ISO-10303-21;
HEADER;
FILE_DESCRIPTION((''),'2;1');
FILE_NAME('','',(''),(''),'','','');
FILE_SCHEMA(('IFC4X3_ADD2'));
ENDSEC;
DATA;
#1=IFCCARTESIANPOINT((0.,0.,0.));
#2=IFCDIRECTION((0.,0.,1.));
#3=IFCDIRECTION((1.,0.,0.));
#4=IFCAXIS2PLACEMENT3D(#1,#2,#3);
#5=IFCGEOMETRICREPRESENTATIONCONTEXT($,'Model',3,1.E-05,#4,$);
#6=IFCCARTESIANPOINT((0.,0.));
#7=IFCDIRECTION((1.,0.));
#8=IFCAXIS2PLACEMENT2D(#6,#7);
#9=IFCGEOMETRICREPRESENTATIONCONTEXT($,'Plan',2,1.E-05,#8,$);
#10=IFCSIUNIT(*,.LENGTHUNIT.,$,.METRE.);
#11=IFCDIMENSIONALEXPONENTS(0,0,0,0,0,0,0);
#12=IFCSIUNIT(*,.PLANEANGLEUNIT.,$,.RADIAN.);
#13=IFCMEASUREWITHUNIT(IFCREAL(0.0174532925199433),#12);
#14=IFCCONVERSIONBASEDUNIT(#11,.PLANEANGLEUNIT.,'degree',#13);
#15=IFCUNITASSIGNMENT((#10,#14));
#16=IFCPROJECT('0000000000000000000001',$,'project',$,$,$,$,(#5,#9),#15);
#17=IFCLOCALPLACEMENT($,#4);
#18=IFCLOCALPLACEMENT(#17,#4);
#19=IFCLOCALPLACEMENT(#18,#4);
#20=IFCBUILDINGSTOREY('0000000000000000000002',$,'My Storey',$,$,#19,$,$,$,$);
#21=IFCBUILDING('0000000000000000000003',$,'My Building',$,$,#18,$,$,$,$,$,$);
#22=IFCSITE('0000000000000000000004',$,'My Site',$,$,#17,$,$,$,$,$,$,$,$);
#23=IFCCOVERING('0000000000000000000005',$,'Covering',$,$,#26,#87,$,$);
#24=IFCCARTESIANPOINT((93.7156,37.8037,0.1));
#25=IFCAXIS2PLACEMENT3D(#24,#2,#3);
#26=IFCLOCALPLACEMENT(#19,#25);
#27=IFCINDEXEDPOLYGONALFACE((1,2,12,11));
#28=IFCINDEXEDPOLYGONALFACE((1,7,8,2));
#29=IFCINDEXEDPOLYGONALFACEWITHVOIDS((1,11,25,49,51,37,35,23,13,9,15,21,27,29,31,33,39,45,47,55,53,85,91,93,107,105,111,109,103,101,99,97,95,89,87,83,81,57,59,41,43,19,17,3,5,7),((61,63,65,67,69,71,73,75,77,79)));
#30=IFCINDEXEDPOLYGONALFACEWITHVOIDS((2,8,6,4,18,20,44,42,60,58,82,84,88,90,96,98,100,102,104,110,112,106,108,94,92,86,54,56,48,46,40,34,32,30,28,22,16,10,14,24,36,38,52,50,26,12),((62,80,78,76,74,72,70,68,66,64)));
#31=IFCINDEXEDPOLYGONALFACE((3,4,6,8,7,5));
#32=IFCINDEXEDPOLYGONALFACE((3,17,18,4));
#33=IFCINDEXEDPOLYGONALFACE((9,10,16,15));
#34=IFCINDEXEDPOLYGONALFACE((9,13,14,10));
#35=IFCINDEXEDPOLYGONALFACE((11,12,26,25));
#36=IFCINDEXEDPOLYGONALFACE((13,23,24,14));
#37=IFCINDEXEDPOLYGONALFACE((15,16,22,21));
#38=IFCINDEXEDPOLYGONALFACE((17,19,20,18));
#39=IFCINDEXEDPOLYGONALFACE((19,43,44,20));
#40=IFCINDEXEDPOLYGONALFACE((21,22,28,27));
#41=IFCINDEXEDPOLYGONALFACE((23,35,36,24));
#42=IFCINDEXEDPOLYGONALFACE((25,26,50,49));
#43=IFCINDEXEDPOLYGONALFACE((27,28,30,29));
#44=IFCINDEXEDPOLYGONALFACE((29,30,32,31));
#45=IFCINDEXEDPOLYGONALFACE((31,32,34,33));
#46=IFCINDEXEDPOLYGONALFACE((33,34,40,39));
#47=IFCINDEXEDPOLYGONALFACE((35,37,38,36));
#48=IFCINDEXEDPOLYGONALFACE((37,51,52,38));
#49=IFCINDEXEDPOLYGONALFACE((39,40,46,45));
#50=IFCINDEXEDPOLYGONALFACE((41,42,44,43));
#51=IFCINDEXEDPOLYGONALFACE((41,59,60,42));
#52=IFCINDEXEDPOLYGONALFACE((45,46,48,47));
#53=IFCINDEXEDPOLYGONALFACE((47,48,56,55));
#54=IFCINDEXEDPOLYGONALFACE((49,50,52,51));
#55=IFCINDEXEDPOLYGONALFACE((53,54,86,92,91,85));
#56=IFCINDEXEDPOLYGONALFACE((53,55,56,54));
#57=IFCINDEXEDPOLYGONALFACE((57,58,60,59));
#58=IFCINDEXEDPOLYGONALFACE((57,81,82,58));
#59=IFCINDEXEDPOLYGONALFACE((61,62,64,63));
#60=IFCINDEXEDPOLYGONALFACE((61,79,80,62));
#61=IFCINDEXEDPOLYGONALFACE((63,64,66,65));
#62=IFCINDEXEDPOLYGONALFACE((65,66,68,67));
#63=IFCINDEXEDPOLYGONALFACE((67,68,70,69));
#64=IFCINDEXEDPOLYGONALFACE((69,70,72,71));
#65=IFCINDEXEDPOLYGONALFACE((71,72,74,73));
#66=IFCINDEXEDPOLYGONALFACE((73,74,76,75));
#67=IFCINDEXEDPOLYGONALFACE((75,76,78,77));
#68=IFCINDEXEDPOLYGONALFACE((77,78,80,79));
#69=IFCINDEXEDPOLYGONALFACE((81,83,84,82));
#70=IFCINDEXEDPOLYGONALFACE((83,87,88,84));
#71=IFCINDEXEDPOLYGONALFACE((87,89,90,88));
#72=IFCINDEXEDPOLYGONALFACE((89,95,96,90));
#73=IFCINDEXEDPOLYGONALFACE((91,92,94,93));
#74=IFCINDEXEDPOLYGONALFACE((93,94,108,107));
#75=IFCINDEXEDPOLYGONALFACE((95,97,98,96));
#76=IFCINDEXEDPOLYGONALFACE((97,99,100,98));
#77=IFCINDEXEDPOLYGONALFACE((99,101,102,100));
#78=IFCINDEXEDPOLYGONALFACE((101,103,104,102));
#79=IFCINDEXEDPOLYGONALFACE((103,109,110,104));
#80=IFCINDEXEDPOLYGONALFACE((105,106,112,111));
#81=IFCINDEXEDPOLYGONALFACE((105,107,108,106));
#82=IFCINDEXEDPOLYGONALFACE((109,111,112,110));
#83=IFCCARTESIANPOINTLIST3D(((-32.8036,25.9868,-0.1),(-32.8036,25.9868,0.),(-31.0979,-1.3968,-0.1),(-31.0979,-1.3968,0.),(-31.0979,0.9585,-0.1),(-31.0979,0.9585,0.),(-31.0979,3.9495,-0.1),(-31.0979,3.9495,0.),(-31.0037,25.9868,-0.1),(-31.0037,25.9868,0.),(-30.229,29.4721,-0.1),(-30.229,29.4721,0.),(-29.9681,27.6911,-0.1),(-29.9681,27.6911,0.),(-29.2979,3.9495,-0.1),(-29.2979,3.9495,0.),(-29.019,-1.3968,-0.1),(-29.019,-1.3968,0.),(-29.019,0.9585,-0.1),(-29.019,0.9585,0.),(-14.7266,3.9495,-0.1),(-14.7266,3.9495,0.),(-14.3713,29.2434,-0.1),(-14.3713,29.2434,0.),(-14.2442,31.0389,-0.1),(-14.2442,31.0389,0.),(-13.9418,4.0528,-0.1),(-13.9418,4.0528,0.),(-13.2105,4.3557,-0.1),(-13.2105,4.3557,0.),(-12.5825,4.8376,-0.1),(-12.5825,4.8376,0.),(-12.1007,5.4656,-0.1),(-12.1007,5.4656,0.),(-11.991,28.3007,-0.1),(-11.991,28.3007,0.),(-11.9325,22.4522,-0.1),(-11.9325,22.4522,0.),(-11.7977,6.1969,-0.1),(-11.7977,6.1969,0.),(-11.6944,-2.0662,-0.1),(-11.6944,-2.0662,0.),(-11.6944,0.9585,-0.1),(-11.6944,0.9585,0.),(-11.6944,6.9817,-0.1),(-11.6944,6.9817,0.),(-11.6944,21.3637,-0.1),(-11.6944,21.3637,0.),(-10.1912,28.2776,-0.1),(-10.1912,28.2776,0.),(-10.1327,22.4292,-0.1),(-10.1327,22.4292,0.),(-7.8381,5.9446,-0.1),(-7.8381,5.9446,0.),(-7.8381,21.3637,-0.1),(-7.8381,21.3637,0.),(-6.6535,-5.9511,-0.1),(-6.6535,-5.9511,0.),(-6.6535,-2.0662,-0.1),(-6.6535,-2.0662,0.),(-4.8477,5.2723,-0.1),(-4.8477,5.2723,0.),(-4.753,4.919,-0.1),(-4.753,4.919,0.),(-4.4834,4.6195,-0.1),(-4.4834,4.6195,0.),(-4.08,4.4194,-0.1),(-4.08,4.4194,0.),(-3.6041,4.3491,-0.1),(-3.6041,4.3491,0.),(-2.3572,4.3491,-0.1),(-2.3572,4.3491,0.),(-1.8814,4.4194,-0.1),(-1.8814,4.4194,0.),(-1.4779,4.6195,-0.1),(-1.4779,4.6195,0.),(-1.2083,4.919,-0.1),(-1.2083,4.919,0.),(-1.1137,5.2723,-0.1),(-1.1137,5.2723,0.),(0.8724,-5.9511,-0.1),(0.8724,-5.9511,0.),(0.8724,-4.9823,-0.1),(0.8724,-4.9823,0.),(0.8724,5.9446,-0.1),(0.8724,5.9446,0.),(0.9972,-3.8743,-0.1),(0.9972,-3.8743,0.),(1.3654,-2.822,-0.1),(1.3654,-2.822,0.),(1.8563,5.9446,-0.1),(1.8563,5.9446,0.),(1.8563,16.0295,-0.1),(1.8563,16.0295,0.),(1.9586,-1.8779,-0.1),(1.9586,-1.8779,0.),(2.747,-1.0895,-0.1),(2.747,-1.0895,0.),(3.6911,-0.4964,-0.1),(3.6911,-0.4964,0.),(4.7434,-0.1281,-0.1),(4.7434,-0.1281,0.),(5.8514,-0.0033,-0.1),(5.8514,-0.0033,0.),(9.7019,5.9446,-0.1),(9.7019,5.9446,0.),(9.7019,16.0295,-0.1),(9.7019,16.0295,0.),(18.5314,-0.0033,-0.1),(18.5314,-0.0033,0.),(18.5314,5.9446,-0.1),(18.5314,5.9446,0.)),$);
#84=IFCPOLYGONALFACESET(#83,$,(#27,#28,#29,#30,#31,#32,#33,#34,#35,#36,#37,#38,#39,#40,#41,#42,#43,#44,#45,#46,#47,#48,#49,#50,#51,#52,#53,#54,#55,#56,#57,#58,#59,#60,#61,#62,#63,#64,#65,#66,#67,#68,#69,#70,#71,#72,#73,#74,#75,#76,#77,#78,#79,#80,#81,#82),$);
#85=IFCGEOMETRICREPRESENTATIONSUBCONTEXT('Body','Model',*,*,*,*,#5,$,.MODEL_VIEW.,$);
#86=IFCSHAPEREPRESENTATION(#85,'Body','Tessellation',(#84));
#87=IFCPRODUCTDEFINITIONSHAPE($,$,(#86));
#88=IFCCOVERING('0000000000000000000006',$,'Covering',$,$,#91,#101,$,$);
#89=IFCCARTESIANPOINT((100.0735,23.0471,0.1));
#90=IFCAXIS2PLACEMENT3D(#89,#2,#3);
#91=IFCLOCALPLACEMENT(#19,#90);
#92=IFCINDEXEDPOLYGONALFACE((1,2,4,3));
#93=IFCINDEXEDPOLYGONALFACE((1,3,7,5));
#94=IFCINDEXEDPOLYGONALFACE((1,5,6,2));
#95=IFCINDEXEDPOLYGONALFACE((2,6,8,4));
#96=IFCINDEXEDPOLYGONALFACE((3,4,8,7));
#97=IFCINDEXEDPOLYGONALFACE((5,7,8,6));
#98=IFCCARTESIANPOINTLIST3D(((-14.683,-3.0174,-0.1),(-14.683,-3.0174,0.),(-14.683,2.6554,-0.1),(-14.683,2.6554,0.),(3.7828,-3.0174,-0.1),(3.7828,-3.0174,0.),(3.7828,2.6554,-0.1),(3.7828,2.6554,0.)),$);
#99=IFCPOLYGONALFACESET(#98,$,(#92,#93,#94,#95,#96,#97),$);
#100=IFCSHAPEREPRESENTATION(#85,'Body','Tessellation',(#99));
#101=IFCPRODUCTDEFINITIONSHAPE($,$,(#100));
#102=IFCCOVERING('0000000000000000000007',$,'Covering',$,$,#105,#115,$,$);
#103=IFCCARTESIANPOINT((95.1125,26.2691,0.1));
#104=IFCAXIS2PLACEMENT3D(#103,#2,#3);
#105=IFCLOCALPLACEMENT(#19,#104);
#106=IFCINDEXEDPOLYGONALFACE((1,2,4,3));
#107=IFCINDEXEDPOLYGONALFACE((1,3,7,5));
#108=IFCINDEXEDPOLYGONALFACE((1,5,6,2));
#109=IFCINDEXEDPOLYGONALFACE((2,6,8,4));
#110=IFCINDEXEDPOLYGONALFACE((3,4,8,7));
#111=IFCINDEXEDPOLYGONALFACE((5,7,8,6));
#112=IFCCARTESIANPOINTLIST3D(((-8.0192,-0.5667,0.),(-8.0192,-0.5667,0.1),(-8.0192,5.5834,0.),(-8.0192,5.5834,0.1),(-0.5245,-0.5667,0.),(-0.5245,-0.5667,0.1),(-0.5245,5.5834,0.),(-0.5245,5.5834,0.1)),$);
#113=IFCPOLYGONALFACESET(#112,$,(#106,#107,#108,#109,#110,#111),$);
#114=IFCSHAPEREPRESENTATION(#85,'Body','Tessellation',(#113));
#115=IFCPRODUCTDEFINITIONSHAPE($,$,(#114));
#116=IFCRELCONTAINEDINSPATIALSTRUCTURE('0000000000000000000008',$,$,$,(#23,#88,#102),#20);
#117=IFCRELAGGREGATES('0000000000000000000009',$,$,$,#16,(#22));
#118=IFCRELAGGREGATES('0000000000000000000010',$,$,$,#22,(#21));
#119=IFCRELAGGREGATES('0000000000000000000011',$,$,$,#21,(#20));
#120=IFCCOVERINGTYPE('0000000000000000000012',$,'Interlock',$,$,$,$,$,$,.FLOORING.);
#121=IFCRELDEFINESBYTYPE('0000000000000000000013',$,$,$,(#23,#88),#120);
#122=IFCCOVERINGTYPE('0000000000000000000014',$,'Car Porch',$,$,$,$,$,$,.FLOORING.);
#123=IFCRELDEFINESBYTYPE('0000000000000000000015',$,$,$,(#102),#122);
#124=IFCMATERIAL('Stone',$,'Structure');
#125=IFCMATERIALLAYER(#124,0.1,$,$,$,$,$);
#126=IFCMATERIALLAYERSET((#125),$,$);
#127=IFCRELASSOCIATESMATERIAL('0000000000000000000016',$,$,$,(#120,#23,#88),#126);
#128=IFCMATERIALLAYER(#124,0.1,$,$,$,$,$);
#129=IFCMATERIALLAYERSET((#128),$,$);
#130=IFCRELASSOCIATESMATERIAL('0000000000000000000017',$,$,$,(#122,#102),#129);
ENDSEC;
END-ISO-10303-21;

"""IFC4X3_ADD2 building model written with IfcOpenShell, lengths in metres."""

from ifc_helpers import new_model, entity, si_unit, converted_unit, frame, origin_with_axes, origin_2d_with_axis, place, context, subcontext, project, spatial, indexed_curve, outline, extrude, material, layer, layer_set, layer_usage, type_object, element, save


model = new_model("IFC4X3_ADD2")

# Units and contexts
model_context = context("Model", 3, precision=1e-05, world=origin_with_axes())
plan_context = context("Plan", 2, precision=1e-05, world=origin_2d_with_axis())
body_context = subcontext(model_context, "Body", "Model", "MODEL_VIEW")
ifc_project = project(units=[si_unit("LENGTHUNIT", "METRE"), converted_unit("PLANEANGLEUNIT", "degree", entity("IfcReal", 0.0174532925199433), si_unit("PLANEANGLEUNIT", "RADIAN"), dimensions=[0, 0, 0, 0, 0, 0, 0])], contexts=[model_context, plan_context])

# Site, building, storey
site_placement = place(None, origin_with_axes())
site = spatial("IfcSite", under=ifc_project, at=site_placement, Name="My Site")
building_placement = place(site_placement, origin_with_axes())
building = spatial("IfcBuilding", under=site, at=building_placement, Name="My Building")
storey_placement = place(building_placement, origin_with_axes())
storey = spatial("IfcBuildingStorey", under=building, at=storey_placement, Name="My Storey")

# Coverings
ifc_material = material(Name="Stone", Category="Structure")
ifc_layer_1 = layer(ifc_material, 0.1)
ifc_layer_set_1 = layer_set([ifc_layer_1])
ifc_layer_usage_1 = layer_usage(ifc_layer_set_1, "AXIS3", "POSITIVE", -0.1)
covering_type_1 = type_object("IfcCoveringType", Name="Interlock", PredefinedType="FLOORING", material=ifc_layer_set_1)
covering_1_placement = place(storey_placement, frame((93.7156, 37.8037, 0.1), z_axis=(0.0, 0.0, 1.0), x_axis=(1.0, 0.0, 0.0)))
element("IfcCovering", 1, at=covering_1_placement, inside=storey, type_object=covering_type_1, material=ifc_layer_usage_1, Name="Covering", context=body_context, shape_type="SweptSolid", body=[
    extrude(outline(indexed_curve([(-29.019, -1.3968), (-31.0979, -1.3968), (-31.0979, 0.9585), (-31.0979, 3.9495), (-32.8036, 25.9868), (-30.229, 29.4721), (-14.2442, 31.0389), (-10.1912, 28.2776), (-10.1327, 22.4292), (-11.9325, 22.4522), (-11.991, 28.3007), (-14.3713, 29.2434), (-29.9681, 27.6911), (-31.0037, 25.9868), (-29.2979, 3.9495), (-14.7266, 3.9495), (-13.9418, 4.0528), (-13.2105, 4.3557), (-12.5825, 4.8376), (-12.1007, 5.4656), (-11.7977, 6.1969), (-11.6944, 6.9817), (-11.6944, 21.3637), (-7.8381, 21.3637), (-7.8381, 5.9446), (0.8724, 5.9446), (1.8563, 5.9446), (1.8563, 16.0295), (9.7019, 16.0295), (9.7019, 5.9446), (18.5314, 5.9446), (18.5314, -0.0033), (5.8514, -0.0033), (4.7434, -0.1281), (3.6911, -0.4964), (2.747, -1.0895), (1.9586, -1.8779), (1.3654, -2.822), (0.9972, -3.8743), (0.8724, -4.9823), (0.8724, -5.9511), (-6.6535, -5.9511), (-6.6535, -2.0662), (-11.6944, -2.0662), (-11.6944, 0.9585), (-29.019, 0.9585), (-29.019, -1.3968)]), holes=[indexed_curve([(-4.8477, 5.2723), (-1.1137, 5.2723), (-1.2083, 4.919), (-1.4779, 4.6195), (-1.8814, 4.4194), (-2.3572, 4.3491), (-3.6041, 4.3491), (-4.08, 4.4194), (-4.4834, 4.6195), (-4.753, 4.919), (-4.8477, 5.2723)])]), frame((0.0, 0.0, -0.1), z_axis=(0.0, 0.0, 1.0), x_axis=(1.0, 0.0, 0.0)), (0.0, 0.0, 1.0), 0.1),
])
ifc_layer_usage_2 = layer_usage(ifc_layer_set_1, "AXIS3", "POSITIVE", -0.1)
covering_2_placement = place(storey_placement, frame((100.0735, 23.0471, 0.1), z_axis=(0.0, 0.0, 1.0), x_axis=(1.0, 0.0, 0.0)))
element("IfcCovering", 2, at=covering_2_placement, inside=storey, type_object=covering_type_1, material=ifc_layer_usage_2, Name="Covering", context=body_context, shape_type="SweptSolid", body=[
    extrude(outline(indexed_curve([(3.7828, -3.0174), (3.7828, 2.6554), (-14.683, 2.6554), (-14.683, -3.0174), (3.7828, -3.0174)])), frame((0.0, 0.0, -0.1), z_axis=(0.0, 0.0, 1.0), x_axis=(1.0, 0.0, 0.0)), (0.0, 0.0, 1.0), 0.1),
])
ifc_layer_2 = layer(ifc_material, 0.1)
ifc_layer_set_2 = layer_set([ifc_layer_2])
ifc_layer_usage_3 = layer_usage(ifc_layer_set_2, "AXIS3", "POSITIVE", 0.0)
covering_type_2 = type_object("IfcCoveringType", Name="Car Porch", PredefinedType="FLOORING", material=ifc_layer_set_2)
covering_3_placement = place(storey_placement, frame((95.1125, 26.2691, 0.1), z_axis=(0.0, 0.0, 1.0), x_axis=(1.0, 0.0, 0.0)))
element("IfcCovering", 3, at=covering_3_placement, inside=storey, type_object=covering_type_2, material=ifc_layer_usage_3, Name="Covering", context=body_context, shape_type="SweptSolid", body=[
    extrude(outline(indexed_curve([(-0.5245, 5.5834), (-8.0192, 5.5834), (-8.0192, -0.5667), (-0.5245, -0.5667), (-0.5245, 5.5834)])), None, (0.0, 0.0, 1.0), 0.1),
])

save(model, "model.ifc")
